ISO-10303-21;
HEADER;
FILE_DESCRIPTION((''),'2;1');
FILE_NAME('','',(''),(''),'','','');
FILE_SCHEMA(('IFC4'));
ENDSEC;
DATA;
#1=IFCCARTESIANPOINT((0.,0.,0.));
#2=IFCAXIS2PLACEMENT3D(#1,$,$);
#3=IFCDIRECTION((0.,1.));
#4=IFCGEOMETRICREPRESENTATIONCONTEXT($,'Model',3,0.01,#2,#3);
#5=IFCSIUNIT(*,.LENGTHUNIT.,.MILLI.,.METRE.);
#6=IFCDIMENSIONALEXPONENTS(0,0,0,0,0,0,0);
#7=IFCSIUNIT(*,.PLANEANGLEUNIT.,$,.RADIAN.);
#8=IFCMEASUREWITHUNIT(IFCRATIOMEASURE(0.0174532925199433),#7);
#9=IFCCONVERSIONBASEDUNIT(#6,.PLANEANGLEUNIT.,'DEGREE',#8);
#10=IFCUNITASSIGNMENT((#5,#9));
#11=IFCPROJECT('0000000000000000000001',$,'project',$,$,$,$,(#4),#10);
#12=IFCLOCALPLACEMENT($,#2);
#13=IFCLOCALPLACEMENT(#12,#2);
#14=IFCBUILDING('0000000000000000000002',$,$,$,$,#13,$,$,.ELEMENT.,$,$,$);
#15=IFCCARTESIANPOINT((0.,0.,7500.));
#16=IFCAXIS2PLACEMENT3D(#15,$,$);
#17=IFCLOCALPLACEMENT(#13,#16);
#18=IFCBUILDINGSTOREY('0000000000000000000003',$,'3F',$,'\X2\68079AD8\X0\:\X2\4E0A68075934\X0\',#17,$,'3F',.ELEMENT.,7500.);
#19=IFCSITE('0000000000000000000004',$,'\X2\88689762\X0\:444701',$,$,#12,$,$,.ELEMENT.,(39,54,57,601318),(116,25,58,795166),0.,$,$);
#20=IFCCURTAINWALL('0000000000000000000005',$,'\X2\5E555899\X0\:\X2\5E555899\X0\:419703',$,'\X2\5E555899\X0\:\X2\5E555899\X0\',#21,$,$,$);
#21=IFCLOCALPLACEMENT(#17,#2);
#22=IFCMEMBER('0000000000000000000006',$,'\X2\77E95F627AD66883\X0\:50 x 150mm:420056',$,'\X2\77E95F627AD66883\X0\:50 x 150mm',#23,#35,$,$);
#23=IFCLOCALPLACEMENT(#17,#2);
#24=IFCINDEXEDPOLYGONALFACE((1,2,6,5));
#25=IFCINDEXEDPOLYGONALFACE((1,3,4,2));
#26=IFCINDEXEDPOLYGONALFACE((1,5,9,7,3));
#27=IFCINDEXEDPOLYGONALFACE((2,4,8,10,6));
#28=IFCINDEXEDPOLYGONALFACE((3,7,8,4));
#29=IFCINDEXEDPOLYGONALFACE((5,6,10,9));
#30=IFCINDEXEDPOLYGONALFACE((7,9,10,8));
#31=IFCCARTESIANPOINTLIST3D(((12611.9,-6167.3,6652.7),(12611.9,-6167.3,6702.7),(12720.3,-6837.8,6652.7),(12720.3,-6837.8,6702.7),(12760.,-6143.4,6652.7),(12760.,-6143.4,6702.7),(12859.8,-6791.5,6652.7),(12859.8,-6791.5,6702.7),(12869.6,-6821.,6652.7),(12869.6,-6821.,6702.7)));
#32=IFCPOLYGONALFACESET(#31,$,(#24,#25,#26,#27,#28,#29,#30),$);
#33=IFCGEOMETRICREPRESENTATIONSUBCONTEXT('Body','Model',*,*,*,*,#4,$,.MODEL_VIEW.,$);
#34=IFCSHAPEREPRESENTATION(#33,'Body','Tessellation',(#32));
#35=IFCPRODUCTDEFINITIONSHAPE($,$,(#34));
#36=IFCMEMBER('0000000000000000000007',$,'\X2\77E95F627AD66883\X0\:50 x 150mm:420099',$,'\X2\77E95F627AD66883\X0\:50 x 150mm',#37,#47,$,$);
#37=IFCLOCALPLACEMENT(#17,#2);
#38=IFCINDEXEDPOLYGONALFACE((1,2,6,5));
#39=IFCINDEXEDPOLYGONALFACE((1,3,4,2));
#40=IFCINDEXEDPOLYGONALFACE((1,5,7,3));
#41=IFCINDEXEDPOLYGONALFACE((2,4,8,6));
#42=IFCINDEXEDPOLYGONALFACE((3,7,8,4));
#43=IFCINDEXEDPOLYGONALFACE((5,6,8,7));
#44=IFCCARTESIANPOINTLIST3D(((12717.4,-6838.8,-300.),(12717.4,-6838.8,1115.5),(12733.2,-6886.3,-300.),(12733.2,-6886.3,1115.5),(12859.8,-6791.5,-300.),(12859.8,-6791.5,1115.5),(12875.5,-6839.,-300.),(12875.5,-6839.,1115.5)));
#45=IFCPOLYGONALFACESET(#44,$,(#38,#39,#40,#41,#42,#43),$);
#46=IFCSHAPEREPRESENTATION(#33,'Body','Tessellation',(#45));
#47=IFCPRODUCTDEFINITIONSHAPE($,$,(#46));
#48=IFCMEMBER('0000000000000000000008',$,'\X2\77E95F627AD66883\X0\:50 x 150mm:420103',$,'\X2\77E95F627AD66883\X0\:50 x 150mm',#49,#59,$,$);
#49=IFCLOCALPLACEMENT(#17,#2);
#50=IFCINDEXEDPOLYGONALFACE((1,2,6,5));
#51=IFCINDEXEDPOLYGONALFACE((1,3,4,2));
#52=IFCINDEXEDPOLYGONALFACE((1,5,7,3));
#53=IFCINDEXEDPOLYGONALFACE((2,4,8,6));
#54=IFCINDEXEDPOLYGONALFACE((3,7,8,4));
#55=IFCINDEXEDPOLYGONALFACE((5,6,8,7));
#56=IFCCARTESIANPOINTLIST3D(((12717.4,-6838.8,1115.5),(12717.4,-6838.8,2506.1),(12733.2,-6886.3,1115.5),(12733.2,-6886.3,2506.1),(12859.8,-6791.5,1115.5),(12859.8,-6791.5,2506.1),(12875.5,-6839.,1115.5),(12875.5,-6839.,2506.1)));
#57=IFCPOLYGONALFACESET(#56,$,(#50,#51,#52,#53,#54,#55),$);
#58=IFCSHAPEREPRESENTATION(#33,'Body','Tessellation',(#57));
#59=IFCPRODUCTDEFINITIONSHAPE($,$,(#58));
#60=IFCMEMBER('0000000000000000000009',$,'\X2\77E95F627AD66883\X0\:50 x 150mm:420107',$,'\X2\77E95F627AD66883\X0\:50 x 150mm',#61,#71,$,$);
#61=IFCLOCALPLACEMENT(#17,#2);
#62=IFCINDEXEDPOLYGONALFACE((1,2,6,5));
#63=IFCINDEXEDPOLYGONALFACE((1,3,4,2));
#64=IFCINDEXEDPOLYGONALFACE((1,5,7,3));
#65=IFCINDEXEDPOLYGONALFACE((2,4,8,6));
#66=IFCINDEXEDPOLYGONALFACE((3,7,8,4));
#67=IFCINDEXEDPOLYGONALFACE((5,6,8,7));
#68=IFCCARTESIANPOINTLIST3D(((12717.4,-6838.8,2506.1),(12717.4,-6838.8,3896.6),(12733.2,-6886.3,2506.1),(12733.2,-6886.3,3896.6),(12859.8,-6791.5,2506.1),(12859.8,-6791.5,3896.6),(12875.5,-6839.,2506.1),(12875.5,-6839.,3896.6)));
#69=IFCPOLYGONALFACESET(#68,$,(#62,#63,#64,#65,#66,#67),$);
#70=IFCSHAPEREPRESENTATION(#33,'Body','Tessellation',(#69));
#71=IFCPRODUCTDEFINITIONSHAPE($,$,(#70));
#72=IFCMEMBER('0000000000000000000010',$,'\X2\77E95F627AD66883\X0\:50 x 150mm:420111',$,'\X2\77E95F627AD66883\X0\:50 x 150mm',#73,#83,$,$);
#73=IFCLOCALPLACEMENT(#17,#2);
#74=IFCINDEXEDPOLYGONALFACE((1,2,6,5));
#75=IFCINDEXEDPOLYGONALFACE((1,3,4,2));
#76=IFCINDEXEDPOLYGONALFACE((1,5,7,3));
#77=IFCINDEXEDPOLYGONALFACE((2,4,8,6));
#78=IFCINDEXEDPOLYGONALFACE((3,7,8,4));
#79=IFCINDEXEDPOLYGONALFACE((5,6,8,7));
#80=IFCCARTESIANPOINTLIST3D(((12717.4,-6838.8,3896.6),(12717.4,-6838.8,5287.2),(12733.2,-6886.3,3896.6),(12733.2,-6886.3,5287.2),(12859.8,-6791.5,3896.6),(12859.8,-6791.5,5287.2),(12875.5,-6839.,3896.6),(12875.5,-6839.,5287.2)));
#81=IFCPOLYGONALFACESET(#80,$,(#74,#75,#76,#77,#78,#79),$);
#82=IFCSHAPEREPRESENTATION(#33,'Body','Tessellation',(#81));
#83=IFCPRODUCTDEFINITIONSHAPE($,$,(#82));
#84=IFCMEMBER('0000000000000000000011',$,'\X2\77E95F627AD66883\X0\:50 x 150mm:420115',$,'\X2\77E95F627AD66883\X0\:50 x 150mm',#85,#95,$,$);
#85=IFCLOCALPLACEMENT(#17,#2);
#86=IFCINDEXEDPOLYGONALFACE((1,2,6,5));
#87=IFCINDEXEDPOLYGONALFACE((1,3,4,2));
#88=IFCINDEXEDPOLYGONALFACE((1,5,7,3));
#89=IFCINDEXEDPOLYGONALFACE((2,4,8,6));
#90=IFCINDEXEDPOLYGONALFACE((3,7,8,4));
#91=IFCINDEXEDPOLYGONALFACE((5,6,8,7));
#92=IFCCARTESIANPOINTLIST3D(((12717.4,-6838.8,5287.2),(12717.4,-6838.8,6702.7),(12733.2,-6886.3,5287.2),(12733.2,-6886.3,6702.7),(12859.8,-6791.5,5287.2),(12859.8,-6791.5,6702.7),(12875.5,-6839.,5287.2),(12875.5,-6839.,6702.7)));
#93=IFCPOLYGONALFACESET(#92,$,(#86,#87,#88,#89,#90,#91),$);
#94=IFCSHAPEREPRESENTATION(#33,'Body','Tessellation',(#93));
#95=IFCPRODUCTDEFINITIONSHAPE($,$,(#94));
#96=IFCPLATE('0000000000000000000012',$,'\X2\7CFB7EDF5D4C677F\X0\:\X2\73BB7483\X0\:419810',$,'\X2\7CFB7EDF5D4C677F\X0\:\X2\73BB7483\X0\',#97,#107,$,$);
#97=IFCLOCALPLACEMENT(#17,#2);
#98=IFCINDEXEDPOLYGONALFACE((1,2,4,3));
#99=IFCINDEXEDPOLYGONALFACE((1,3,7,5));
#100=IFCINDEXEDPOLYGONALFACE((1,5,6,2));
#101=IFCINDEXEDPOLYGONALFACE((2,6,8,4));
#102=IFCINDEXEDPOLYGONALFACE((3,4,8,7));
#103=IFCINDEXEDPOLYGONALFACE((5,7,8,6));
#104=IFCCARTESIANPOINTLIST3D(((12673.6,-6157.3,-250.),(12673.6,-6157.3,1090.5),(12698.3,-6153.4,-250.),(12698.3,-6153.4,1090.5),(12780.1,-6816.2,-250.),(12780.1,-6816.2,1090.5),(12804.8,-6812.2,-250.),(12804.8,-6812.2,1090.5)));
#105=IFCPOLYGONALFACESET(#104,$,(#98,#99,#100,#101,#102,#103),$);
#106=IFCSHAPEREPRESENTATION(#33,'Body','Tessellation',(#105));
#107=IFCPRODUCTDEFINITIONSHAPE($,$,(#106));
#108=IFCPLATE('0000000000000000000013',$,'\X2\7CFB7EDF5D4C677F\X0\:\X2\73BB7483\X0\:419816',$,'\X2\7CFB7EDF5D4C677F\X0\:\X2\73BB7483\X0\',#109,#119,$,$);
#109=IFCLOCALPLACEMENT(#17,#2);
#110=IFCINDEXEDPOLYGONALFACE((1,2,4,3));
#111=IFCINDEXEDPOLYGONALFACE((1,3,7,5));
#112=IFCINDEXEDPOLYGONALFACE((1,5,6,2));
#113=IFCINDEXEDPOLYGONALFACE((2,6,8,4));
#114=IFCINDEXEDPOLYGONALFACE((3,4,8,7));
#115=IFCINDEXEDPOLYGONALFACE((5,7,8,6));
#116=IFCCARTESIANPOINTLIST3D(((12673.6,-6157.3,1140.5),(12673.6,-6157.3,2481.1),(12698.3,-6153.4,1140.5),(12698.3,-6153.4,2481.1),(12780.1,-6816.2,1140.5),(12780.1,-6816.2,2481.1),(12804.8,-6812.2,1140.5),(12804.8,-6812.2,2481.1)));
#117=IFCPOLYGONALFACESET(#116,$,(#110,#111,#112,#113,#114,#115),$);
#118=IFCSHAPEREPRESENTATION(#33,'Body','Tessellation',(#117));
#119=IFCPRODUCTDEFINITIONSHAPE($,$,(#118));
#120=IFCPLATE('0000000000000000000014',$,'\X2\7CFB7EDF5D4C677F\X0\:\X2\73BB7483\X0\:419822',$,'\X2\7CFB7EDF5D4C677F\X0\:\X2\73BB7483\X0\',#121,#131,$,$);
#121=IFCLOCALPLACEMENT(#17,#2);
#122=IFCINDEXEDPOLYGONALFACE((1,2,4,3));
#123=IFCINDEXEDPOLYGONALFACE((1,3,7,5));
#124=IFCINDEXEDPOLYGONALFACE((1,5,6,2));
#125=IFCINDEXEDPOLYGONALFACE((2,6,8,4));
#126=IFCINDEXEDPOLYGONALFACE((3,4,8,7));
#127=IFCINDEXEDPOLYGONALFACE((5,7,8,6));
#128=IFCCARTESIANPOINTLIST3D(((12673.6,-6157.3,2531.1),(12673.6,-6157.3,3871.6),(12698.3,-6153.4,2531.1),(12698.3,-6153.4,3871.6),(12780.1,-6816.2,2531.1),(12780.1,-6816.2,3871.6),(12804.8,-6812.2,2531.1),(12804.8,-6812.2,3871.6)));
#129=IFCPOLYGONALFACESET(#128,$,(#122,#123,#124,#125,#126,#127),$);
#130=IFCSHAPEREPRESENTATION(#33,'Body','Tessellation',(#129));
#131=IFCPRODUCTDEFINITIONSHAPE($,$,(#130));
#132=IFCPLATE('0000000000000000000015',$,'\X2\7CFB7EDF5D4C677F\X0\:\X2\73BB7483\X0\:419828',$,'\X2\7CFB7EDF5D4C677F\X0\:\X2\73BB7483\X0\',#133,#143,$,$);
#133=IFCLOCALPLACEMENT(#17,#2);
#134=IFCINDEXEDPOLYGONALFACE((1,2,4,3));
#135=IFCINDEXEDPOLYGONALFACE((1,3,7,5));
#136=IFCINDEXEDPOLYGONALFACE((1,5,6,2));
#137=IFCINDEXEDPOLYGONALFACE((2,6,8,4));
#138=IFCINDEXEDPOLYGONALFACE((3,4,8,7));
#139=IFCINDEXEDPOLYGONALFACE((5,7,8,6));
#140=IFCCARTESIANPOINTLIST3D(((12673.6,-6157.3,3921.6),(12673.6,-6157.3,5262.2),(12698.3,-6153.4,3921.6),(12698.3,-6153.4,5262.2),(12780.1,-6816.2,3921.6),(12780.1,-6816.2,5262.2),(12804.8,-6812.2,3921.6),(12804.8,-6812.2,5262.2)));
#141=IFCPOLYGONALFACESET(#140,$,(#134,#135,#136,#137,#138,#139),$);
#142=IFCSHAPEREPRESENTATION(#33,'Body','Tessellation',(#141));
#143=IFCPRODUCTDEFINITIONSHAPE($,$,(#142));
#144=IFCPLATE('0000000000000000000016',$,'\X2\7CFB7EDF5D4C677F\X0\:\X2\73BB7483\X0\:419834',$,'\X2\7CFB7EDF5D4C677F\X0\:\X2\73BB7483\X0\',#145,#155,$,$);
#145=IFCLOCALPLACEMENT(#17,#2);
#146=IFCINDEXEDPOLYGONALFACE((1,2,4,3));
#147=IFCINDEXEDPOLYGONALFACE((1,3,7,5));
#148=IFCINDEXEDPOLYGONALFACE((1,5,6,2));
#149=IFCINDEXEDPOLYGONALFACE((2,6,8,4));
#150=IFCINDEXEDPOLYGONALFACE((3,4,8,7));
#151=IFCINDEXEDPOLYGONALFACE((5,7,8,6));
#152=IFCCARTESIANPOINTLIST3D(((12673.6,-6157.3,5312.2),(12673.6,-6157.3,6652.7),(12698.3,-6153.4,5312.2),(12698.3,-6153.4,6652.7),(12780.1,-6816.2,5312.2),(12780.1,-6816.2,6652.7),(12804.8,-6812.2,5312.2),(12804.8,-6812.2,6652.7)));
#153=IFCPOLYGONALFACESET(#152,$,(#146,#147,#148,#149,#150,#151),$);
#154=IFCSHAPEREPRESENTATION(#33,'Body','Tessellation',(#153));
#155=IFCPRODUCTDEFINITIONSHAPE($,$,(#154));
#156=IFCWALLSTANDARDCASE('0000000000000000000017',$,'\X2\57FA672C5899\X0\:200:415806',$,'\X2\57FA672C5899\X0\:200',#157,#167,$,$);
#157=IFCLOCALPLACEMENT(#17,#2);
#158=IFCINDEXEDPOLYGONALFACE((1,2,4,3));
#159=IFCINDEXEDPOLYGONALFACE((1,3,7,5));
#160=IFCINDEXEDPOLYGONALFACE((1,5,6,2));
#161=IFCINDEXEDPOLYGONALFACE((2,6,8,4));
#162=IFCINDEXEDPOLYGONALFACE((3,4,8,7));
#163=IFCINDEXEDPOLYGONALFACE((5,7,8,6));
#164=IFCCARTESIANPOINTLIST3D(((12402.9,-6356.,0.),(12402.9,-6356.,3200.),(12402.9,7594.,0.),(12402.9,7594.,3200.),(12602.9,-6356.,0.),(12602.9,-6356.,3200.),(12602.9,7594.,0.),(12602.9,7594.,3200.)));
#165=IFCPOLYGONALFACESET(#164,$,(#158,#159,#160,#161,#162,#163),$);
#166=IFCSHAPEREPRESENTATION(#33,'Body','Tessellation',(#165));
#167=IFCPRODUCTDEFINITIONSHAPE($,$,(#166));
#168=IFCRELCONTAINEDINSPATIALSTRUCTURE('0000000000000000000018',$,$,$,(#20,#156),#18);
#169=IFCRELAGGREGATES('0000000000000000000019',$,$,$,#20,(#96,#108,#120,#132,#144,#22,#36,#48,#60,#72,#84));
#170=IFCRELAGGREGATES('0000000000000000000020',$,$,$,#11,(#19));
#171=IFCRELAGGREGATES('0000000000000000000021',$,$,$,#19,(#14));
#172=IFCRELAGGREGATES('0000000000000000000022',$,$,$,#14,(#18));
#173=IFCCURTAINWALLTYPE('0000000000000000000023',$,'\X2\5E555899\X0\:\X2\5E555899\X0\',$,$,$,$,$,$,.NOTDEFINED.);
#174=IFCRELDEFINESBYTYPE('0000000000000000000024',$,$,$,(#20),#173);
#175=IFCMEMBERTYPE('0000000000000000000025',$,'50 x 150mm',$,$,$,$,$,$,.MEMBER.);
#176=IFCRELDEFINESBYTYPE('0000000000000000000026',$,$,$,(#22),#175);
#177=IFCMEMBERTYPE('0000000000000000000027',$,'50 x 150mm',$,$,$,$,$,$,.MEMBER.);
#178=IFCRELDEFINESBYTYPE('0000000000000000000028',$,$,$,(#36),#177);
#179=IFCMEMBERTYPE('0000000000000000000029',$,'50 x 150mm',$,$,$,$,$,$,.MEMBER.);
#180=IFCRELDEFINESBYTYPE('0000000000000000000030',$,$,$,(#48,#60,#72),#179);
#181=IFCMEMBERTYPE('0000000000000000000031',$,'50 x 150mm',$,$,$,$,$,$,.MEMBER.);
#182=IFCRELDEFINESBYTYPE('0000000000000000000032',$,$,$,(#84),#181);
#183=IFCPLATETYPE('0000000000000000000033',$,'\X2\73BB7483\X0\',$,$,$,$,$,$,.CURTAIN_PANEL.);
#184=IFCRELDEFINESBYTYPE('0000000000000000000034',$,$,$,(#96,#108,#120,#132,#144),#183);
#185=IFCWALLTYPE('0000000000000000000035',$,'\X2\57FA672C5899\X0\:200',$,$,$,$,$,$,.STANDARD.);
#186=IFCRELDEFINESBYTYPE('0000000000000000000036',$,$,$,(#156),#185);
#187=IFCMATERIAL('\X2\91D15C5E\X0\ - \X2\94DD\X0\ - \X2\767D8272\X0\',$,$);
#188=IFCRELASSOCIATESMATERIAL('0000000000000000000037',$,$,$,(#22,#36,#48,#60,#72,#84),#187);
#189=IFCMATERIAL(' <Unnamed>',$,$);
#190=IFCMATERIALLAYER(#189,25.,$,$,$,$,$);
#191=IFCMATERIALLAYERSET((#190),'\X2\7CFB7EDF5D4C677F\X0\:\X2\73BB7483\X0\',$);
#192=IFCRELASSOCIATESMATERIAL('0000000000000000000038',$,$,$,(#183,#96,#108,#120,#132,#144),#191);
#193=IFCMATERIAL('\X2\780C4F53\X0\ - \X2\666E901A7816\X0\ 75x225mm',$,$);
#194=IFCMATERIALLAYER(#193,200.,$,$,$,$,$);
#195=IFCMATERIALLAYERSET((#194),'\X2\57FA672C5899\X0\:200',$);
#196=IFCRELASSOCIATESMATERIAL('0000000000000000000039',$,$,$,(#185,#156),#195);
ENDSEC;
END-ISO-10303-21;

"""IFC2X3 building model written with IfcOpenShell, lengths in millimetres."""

from ifc_helpers import new_model, entity, si_unit, converted_unit, direction, frame, frame_2d, origin, origin_2d_with_axis, place, context, subcontext, project, spatial, polyline, rectangle, extrude, clip, bounded_halfspace, source, transform, mapped, material, layer, layer_set, layer_usage, type_object, type_shapes, element, aggregate, save


model = new_model("IFC2X3")

# Units and contexts
model_context = context("Model", 3, precision=0.01, world=origin(), true_north=direction((0.0, 1.0)))
body_context = subcontext(model_context, "Body", "Model", "MODEL_VIEW")
ifc_project = project(units=[si_unit("LENGTHUNIT", "METRE", prefix="MILLI"), converted_unit("PLANEANGLEUNIT", "DEGREE", entity("IfcRatioMeasure", 0.0174532925199433), si_unit("PLANEANGLEUNIT", "RADIAN"), dimensions=[0, 0, 0, 0, 0, 0, 0])], contexts=[model_context])

# Site, building, storey
site_placement = place(None, origin())
site = spatial("IfcSite", under=ifc_project, at=site_placement, Name="表面:444701", CompositionType="ELEMENT", RefLatitude=(39, 54, 57, 601318), RefLongitude=(116, 25, 58, 795166), RefElevation=0.0)
building_placement = place(site_placement, origin())
building = spatial("IfcBuilding", under=site, at=building_placement, CompositionType="ELEMENT")
storey_placement = place(building_placement, frame((0.0, 0.0, 7500.0)))
storey = spatial("IfcBuildingStorey", under=building, at=storey_placement, Name="3F", ObjectType="标高:上标头", LongName="3F", CompositionType="ELEMENT", Elevation=7500.0)

# Shared definitions
curtain_wall_type = type_object("IfcCurtainWallType", Name="幕墙:幕墙", PredefinedType="NOTDEFINED")
ifc_material_1 = material(Name="金属 - 铝 - 白色")

# Curtain wall, members, plates
curtain_wall_1_placement = place(storey_placement, frame((0.0, 0.0, -7500.0)))
curtain_wall_1 = element("IfcCurtainWall", 1, at=curtain_wall_1_placement, inside=storey, type_object=curtain_wall_type, Name="幕墙:幕墙:419703", ObjectType="幕墙:幕墙")
member_type_1 = type_object("IfcMemberType", Name="50 x 150mm", PredefinedType="MEMBER")
shared_shape_1 = source(origin(), body_context, "Body", "Clipping", [
    clip(clip(extrude(rectangle(XDim=50.0, YDim=150.0, at=frame_2d((0.0, 0.0), x_axis=(1.0, 0.0))), frame((-25.0, 0.0, -686.4)), (0.0, 0.0, 1.0), 686.4), bounded_halfspace(frame((-1415.5, -78.0, -679.7), z_axis=(0.0, 0.15966, -0.987172), x_axis=(1.0, 0.0, 0.0)), False, frame((-25.0, 0.0, -686.4)), polyline([(25.0, 70.0), (25.0, -75.0), (-25.0, -75.0), (-25.0, 70.0), (25.0, 70.0)]))), bounded_halfspace(frame((-1415.5, 70.0, -655.8), z_axis=(0.0, -0.987172, -0.15966), x_axis=(1.0, 0.0, 0.0)), False, frame((-25.0, 0.0, -686.4)), polyline([(25.0, 75.0), (25.0, 70.0), (-25.0, 70.0), (-25.0, 75.0), (25.0, 75.0)]))),
])
type_shapes(member_type_1, [shared_shape_1])
member_1_placement = place(storey_placement, frame((12685.9, -6155.4, 6702.7), z_axis=(-0.15966, 0.987172, 0.0), x_axis=(0.0, 0.0, 1.0)))
member_1 = element("IfcMember", 2, at=member_1_placement, type_object=member_type_1, material=ifc_material_1, Name="矩形竖梃:50 x 150mm:420056", ObjectType="矩形竖梃:50 x 150mm", context=body_context, shape_type="MappedRepresentation", body=[
    mapped(shared_shape_1, transform((0.0, 0.0, 0.0), scale=1.0)),
])
member_type_2 = type_object("IfcMemberType", Name="50 x 150mm", PredefinedType="MEMBER")
shared_shape_2 = source(origin(), body_context, "Body", "SweptSolid", [
    extrude(rectangle(XDim=150.0, YDim=50.0, at=origin_2d_with_axis()), frame((0.0, 0.0, -1415.5), z_axis=(0.0, 0.0, 1.0), x_axis=(0.0, -1.0, 0.0)), (0.0, 0.0, 1.0), 1415.5),
])
type_shapes(member_type_2, [shared_shape_2])
member_2_placement = place(storey_placement, frame((12796.5, -6838.9, -300.0), z_axis=(0.0, 0.0, -1.0), x_axis=(-0.315223, 0.949018, 0.0)))
member_2 = element("IfcMember", 3, at=member_2_placement, type_object=member_type_2, material=ifc_material_1, Name="矩形竖梃:50 x 150mm:420099", ObjectType="矩形竖梃:50 x 150mm", context=body_context, shape_type="MappedRepresentation", body=[
    mapped(shared_shape_2, transform((0.0, 0.0, 0.0), scale=1.0)),
])
member_type_3 = type_object("IfcMemberType", Name="50 x 150mm", PredefinedType="MEMBER")
shared_shape_3 = source(origin(), body_context, "Body", "SweptSolid", [
    extrude(rectangle(XDim=150.0, YDim=50.0, at=origin_2d_with_axis()), frame((0.0, 0.0, -1390.5), z_axis=(0.0, 0.0, 1.0), x_axis=(0.0, -1.0, 0.0)), (0.0, 0.0, 1.0), 1390.5),
])
type_shapes(member_type_3, [shared_shape_3])
member_3_placement = place(storey_placement, frame((12796.5, -6838.9, 1115.5), z_axis=(0.0, 0.0, -1.0), x_axis=(-0.315223, 0.949018, 0.0)))
member_3 = element("IfcMember", 4, at=member_3_placement, type_object=member_type_3, material=ifc_material_1, Name="矩形竖梃:50 x 150mm:420103", ObjectType="矩形竖梃:50 x 150mm", context=body_context, shape_type="MappedRepresentation", body=[
    mapped(shared_shape_3, transform((0.0, 0.0, 0.0), scale=1.0)),
])
member_4_placement = place(storey_placement, frame((12796.5, -6838.9, 2506.1), z_axis=(0.0, 0.0, -1.0), x_axis=(-0.315223, 0.949018, 0.0)))
member_4 = element("IfcMember", 5, at=member_4_placement, type_object=member_type_3, material=ifc_material_1, Name="矩形竖梃:50 x 150mm:420107", ObjectType="矩形竖梃:50 x 150mm", context=body_context, shape_type="MappedRepresentation", body=[
    mapped(shared_shape_3, transform((0.0, 0.0, 0.0), scale=1.0)),
])
member_5_placement = place(storey_placement, frame((12796.5, -6838.9, 3896.6), z_axis=(0.0, 0.0, -1.0), x_axis=(-0.315223, 0.949018, 0.0)))
member_5 = element("IfcMember", 6, at=member_5_placement, type_object=member_type_3, material=ifc_material_1, Name="矩形竖梃:50 x 150mm:420111", ObjectType="矩形竖梃:50 x 150mm", context=body_context, shape_type="MappedRepresentation", body=[
    mapped(shared_shape_3, transform((0.0, 0.0, 0.0), scale=1.0)),
])
member_type_4 = type_object("IfcMemberType", Name="50 x 150mm", PredefinedType="MEMBER")
shared_shape_4 = source(origin(), body_context, "Body", "SweptSolid", [
    extrude(rectangle(XDim=150.0, YDim=50.0, at=origin_2d_with_axis()), frame((0.0, 0.0, -1415.5), z_axis=(0.0, 0.0, 1.0), x_axis=(0.0, -1.0, 0.0)), (0.0, 0.0, 1.0), 1415.5),
])
type_shapes(member_type_4, [shared_shape_4])
member_6_placement = place(storey_placement, frame((12796.5, -6838.9, 5287.2), z_axis=(0.0, 0.0, -1.0), x_axis=(-0.315223, 0.949018, 0.0)))
member_6 = element("IfcMember", 7, at=member_6_placement, type_object=member_type_4, material=ifc_material_1, Name="矩形竖梃:50 x 150mm:420115", ObjectType="矩形竖梃:50 x 150mm", context=body_context, shape_type="MappedRepresentation", body=[
    mapped(shared_shape_4, transform((0.0, 0.0, 0.0), scale=1.0)),
])
ifc_material_2 = material(Name=" <Unnamed>")
ifc_layer_1 = layer(ifc_material_2, 25.0)
ifc_layer_set_1 = layer_set([ifc_layer_1], Name="系统嵌板:玻璃")
ifc_layer_usage_1 = layer_usage(ifc_layer_set_1, "AXIS3", "POSITIVE", 0.0)
plate_type = type_object("IfcPlateType", Name="玻璃", PredefinedType="CURTAIN_PANEL", material=ifc_layer_set_1)
shared_shape_5 = source(origin(), body_context, "Body", "SweptSolid", [
    extrude(rectangle(XDim=25.0, YDim=667.4, at=frame_2d((0.0, 0.0), x_axis=(1.0, 0.0))), frame((0.0, 0.0, 0.0), z_axis=(0.0, 0.0, 1.0), x_axis=(0.0, 1.0, 0.0)), (0.0, 0.0, 1.0), 1340.5),
])
type_shapes(plate_type, [shared_shape_5])
plate_1_placement = place(curtain_wall_1_placement, frame((12739.2, -6484.8, 7250.0), z_axis=(0.0, 0.0, 1.0), x_axis=(-0.15966, 0.987172, 0.0)))
plate_1 = element("IfcPlate", 8, at=plate_1_placement, type_object=plate_type, material=ifc_layer_usage_1, Name="系统嵌板:玻璃:419810", ObjectType="系统嵌板:玻璃", context=body_context, shape_type="MappedRepresentation", body=[
    mapped(shared_shape_5, transform((0.0, 0.0, 0.0), scale=1.0)),
])
ifc_layer_usage_2 = layer_usage(ifc_layer_set_1, "AXIS3", "POSITIVE", 0.0)
plate_2_placement = place(curtain_wall_1_placement, frame((12739.2, -6484.8, 8640.5), z_axis=(0.0, 0.0, 1.0), x_axis=(-0.15966, 0.987172, 0.0)))
plate_2 = element("IfcPlate", 9, at=plate_2_placement, type_object=plate_type, material=ifc_layer_usage_2, Name="系统嵌板:玻璃:419816", ObjectType="系统嵌板:玻璃", context=body_context, shape_type="MappedRepresentation", body=[
    mapped(shared_shape_5, transform((0.0, 0.0, 0.0), scale=1.0)),
])
ifc_layer_usage_3 = layer_usage(ifc_layer_set_1, "AXIS3", "POSITIVE", 0.0)
plate_3_placement = place(curtain_wall_1_placement, frame((12739.2, -6484.8, 10031.1), z_axis=(0.0, 0.0, 1.0), x_axis=(-0.15966, 0.987172, 0.0)))
plate_3 = element("IfcPlate", 10, at=plate_3_placement, type_object=plate_type, material=ifc_layer_usage_3, Name="系统嵌板:玻璃:419822", ObjectType="系统嵌板:玻璃", context=body_context, shape_type="MappedRepresentation", body=[
    mapped(shared_shape_5, transform((0.0, 0.0, 0.0), scale=1.0)),
])
ifc_layer_usage_4 = layer_usage(ifc_layer_set_1, "AXIS3", "POSITIVE", 0.0)
plate_4_placement = place(curtain_wall_1_placement, frame((12739.2, -6484.8, 11421.6), z_axis=(0.0, 0.0, 1.0), x_axis=(-0.15966, 0.987172, 0.0)))
plate_4 = element("IfcPlate", 11, at=plate_4_placement, type_object=plate_type, material=ifc_layer_usage_4, Name="系统嵌板:玻璃:419828", ObjectType="系统嵌板:玻璃", context=body_context, shape_type="MappedRepresentation", body=[
    mapped(shared_shape_5, transform((0.0, 0.0, 0.0), scale=1.0)),
])
ifc_layer_usage_5 = layer_usage(ifc_layer_set_1, "AXIS3", "POSITIVE", 0.0)
plate_5_placement = place(curtain_wall_1_placement, frame((12739.2, -6484.8, 12812.2), z_axis=(0.0, 0.0, 1.0), x_axis=(-0.15966, 0.987172, 0.0)))
plate_5 = element("IfcPlate", 12, at=plate_5_placement, type_object=plate_type, material=ifc_layer_usage_5, Name="系统嵌板:玻璃:419834", ObjectType="系统嵌板:玻璃", context=body_context, shape_type="MappedRepresentation", body=[
    mapped(shared_shape_5, transform((0.0, 0.0, 0.0), scale=1.0)),
])
aggregate(curtain_wall_1, [plate_1, plate_2, plate_3, plate_4, plate_5, member_1, member_2, member_3, member_4, member_5, member_6])

# Shared definitions
ifc_material_3 = material(Name="砌体 - 普通砖 75x225mm")

# Wall
ifc_layer_2 = layer(ifc_material_3, 200.0)
ifc_layer_set_2 = layer_set([ifc_layer_2], Name="基本墙:200")
ifc_layer_usage_6 = layer_usage(ifc_layer_set_2, "AXIS2", "NEGATIVE", 100.0)
wall_type_1 = type_object("IfcWallType", Name="基本墙:200", PredefinedType="STANDARD", material=ifc_layer_set_2)
wall_1_placement = place(storey_placement, frame((12502.9, -6356.0, 0.0), z_axis=(0.0, 0.0, 1.0), x_axis=(0.0, 1.0, 0.0)))
element("IfcWallStandardCase", 13, at=wall_1_placement, inside=storey, type_object=wall_type_1, material=ifc_layer_usage_6, Name="基本墙:200:415806", ObjectType="基本墙:200", context=body_context, shape_type="SweptSolid", body=[
    extrude(rectangle(XDim=13950.0, YDim=200.0, at=frame_2d((6975.0, 0.0), x_axis=(-1.0, 0.0))), origin(), (0.0, 0.0, 1.0), 3200.0),
])

save(model, "model.ifc")
